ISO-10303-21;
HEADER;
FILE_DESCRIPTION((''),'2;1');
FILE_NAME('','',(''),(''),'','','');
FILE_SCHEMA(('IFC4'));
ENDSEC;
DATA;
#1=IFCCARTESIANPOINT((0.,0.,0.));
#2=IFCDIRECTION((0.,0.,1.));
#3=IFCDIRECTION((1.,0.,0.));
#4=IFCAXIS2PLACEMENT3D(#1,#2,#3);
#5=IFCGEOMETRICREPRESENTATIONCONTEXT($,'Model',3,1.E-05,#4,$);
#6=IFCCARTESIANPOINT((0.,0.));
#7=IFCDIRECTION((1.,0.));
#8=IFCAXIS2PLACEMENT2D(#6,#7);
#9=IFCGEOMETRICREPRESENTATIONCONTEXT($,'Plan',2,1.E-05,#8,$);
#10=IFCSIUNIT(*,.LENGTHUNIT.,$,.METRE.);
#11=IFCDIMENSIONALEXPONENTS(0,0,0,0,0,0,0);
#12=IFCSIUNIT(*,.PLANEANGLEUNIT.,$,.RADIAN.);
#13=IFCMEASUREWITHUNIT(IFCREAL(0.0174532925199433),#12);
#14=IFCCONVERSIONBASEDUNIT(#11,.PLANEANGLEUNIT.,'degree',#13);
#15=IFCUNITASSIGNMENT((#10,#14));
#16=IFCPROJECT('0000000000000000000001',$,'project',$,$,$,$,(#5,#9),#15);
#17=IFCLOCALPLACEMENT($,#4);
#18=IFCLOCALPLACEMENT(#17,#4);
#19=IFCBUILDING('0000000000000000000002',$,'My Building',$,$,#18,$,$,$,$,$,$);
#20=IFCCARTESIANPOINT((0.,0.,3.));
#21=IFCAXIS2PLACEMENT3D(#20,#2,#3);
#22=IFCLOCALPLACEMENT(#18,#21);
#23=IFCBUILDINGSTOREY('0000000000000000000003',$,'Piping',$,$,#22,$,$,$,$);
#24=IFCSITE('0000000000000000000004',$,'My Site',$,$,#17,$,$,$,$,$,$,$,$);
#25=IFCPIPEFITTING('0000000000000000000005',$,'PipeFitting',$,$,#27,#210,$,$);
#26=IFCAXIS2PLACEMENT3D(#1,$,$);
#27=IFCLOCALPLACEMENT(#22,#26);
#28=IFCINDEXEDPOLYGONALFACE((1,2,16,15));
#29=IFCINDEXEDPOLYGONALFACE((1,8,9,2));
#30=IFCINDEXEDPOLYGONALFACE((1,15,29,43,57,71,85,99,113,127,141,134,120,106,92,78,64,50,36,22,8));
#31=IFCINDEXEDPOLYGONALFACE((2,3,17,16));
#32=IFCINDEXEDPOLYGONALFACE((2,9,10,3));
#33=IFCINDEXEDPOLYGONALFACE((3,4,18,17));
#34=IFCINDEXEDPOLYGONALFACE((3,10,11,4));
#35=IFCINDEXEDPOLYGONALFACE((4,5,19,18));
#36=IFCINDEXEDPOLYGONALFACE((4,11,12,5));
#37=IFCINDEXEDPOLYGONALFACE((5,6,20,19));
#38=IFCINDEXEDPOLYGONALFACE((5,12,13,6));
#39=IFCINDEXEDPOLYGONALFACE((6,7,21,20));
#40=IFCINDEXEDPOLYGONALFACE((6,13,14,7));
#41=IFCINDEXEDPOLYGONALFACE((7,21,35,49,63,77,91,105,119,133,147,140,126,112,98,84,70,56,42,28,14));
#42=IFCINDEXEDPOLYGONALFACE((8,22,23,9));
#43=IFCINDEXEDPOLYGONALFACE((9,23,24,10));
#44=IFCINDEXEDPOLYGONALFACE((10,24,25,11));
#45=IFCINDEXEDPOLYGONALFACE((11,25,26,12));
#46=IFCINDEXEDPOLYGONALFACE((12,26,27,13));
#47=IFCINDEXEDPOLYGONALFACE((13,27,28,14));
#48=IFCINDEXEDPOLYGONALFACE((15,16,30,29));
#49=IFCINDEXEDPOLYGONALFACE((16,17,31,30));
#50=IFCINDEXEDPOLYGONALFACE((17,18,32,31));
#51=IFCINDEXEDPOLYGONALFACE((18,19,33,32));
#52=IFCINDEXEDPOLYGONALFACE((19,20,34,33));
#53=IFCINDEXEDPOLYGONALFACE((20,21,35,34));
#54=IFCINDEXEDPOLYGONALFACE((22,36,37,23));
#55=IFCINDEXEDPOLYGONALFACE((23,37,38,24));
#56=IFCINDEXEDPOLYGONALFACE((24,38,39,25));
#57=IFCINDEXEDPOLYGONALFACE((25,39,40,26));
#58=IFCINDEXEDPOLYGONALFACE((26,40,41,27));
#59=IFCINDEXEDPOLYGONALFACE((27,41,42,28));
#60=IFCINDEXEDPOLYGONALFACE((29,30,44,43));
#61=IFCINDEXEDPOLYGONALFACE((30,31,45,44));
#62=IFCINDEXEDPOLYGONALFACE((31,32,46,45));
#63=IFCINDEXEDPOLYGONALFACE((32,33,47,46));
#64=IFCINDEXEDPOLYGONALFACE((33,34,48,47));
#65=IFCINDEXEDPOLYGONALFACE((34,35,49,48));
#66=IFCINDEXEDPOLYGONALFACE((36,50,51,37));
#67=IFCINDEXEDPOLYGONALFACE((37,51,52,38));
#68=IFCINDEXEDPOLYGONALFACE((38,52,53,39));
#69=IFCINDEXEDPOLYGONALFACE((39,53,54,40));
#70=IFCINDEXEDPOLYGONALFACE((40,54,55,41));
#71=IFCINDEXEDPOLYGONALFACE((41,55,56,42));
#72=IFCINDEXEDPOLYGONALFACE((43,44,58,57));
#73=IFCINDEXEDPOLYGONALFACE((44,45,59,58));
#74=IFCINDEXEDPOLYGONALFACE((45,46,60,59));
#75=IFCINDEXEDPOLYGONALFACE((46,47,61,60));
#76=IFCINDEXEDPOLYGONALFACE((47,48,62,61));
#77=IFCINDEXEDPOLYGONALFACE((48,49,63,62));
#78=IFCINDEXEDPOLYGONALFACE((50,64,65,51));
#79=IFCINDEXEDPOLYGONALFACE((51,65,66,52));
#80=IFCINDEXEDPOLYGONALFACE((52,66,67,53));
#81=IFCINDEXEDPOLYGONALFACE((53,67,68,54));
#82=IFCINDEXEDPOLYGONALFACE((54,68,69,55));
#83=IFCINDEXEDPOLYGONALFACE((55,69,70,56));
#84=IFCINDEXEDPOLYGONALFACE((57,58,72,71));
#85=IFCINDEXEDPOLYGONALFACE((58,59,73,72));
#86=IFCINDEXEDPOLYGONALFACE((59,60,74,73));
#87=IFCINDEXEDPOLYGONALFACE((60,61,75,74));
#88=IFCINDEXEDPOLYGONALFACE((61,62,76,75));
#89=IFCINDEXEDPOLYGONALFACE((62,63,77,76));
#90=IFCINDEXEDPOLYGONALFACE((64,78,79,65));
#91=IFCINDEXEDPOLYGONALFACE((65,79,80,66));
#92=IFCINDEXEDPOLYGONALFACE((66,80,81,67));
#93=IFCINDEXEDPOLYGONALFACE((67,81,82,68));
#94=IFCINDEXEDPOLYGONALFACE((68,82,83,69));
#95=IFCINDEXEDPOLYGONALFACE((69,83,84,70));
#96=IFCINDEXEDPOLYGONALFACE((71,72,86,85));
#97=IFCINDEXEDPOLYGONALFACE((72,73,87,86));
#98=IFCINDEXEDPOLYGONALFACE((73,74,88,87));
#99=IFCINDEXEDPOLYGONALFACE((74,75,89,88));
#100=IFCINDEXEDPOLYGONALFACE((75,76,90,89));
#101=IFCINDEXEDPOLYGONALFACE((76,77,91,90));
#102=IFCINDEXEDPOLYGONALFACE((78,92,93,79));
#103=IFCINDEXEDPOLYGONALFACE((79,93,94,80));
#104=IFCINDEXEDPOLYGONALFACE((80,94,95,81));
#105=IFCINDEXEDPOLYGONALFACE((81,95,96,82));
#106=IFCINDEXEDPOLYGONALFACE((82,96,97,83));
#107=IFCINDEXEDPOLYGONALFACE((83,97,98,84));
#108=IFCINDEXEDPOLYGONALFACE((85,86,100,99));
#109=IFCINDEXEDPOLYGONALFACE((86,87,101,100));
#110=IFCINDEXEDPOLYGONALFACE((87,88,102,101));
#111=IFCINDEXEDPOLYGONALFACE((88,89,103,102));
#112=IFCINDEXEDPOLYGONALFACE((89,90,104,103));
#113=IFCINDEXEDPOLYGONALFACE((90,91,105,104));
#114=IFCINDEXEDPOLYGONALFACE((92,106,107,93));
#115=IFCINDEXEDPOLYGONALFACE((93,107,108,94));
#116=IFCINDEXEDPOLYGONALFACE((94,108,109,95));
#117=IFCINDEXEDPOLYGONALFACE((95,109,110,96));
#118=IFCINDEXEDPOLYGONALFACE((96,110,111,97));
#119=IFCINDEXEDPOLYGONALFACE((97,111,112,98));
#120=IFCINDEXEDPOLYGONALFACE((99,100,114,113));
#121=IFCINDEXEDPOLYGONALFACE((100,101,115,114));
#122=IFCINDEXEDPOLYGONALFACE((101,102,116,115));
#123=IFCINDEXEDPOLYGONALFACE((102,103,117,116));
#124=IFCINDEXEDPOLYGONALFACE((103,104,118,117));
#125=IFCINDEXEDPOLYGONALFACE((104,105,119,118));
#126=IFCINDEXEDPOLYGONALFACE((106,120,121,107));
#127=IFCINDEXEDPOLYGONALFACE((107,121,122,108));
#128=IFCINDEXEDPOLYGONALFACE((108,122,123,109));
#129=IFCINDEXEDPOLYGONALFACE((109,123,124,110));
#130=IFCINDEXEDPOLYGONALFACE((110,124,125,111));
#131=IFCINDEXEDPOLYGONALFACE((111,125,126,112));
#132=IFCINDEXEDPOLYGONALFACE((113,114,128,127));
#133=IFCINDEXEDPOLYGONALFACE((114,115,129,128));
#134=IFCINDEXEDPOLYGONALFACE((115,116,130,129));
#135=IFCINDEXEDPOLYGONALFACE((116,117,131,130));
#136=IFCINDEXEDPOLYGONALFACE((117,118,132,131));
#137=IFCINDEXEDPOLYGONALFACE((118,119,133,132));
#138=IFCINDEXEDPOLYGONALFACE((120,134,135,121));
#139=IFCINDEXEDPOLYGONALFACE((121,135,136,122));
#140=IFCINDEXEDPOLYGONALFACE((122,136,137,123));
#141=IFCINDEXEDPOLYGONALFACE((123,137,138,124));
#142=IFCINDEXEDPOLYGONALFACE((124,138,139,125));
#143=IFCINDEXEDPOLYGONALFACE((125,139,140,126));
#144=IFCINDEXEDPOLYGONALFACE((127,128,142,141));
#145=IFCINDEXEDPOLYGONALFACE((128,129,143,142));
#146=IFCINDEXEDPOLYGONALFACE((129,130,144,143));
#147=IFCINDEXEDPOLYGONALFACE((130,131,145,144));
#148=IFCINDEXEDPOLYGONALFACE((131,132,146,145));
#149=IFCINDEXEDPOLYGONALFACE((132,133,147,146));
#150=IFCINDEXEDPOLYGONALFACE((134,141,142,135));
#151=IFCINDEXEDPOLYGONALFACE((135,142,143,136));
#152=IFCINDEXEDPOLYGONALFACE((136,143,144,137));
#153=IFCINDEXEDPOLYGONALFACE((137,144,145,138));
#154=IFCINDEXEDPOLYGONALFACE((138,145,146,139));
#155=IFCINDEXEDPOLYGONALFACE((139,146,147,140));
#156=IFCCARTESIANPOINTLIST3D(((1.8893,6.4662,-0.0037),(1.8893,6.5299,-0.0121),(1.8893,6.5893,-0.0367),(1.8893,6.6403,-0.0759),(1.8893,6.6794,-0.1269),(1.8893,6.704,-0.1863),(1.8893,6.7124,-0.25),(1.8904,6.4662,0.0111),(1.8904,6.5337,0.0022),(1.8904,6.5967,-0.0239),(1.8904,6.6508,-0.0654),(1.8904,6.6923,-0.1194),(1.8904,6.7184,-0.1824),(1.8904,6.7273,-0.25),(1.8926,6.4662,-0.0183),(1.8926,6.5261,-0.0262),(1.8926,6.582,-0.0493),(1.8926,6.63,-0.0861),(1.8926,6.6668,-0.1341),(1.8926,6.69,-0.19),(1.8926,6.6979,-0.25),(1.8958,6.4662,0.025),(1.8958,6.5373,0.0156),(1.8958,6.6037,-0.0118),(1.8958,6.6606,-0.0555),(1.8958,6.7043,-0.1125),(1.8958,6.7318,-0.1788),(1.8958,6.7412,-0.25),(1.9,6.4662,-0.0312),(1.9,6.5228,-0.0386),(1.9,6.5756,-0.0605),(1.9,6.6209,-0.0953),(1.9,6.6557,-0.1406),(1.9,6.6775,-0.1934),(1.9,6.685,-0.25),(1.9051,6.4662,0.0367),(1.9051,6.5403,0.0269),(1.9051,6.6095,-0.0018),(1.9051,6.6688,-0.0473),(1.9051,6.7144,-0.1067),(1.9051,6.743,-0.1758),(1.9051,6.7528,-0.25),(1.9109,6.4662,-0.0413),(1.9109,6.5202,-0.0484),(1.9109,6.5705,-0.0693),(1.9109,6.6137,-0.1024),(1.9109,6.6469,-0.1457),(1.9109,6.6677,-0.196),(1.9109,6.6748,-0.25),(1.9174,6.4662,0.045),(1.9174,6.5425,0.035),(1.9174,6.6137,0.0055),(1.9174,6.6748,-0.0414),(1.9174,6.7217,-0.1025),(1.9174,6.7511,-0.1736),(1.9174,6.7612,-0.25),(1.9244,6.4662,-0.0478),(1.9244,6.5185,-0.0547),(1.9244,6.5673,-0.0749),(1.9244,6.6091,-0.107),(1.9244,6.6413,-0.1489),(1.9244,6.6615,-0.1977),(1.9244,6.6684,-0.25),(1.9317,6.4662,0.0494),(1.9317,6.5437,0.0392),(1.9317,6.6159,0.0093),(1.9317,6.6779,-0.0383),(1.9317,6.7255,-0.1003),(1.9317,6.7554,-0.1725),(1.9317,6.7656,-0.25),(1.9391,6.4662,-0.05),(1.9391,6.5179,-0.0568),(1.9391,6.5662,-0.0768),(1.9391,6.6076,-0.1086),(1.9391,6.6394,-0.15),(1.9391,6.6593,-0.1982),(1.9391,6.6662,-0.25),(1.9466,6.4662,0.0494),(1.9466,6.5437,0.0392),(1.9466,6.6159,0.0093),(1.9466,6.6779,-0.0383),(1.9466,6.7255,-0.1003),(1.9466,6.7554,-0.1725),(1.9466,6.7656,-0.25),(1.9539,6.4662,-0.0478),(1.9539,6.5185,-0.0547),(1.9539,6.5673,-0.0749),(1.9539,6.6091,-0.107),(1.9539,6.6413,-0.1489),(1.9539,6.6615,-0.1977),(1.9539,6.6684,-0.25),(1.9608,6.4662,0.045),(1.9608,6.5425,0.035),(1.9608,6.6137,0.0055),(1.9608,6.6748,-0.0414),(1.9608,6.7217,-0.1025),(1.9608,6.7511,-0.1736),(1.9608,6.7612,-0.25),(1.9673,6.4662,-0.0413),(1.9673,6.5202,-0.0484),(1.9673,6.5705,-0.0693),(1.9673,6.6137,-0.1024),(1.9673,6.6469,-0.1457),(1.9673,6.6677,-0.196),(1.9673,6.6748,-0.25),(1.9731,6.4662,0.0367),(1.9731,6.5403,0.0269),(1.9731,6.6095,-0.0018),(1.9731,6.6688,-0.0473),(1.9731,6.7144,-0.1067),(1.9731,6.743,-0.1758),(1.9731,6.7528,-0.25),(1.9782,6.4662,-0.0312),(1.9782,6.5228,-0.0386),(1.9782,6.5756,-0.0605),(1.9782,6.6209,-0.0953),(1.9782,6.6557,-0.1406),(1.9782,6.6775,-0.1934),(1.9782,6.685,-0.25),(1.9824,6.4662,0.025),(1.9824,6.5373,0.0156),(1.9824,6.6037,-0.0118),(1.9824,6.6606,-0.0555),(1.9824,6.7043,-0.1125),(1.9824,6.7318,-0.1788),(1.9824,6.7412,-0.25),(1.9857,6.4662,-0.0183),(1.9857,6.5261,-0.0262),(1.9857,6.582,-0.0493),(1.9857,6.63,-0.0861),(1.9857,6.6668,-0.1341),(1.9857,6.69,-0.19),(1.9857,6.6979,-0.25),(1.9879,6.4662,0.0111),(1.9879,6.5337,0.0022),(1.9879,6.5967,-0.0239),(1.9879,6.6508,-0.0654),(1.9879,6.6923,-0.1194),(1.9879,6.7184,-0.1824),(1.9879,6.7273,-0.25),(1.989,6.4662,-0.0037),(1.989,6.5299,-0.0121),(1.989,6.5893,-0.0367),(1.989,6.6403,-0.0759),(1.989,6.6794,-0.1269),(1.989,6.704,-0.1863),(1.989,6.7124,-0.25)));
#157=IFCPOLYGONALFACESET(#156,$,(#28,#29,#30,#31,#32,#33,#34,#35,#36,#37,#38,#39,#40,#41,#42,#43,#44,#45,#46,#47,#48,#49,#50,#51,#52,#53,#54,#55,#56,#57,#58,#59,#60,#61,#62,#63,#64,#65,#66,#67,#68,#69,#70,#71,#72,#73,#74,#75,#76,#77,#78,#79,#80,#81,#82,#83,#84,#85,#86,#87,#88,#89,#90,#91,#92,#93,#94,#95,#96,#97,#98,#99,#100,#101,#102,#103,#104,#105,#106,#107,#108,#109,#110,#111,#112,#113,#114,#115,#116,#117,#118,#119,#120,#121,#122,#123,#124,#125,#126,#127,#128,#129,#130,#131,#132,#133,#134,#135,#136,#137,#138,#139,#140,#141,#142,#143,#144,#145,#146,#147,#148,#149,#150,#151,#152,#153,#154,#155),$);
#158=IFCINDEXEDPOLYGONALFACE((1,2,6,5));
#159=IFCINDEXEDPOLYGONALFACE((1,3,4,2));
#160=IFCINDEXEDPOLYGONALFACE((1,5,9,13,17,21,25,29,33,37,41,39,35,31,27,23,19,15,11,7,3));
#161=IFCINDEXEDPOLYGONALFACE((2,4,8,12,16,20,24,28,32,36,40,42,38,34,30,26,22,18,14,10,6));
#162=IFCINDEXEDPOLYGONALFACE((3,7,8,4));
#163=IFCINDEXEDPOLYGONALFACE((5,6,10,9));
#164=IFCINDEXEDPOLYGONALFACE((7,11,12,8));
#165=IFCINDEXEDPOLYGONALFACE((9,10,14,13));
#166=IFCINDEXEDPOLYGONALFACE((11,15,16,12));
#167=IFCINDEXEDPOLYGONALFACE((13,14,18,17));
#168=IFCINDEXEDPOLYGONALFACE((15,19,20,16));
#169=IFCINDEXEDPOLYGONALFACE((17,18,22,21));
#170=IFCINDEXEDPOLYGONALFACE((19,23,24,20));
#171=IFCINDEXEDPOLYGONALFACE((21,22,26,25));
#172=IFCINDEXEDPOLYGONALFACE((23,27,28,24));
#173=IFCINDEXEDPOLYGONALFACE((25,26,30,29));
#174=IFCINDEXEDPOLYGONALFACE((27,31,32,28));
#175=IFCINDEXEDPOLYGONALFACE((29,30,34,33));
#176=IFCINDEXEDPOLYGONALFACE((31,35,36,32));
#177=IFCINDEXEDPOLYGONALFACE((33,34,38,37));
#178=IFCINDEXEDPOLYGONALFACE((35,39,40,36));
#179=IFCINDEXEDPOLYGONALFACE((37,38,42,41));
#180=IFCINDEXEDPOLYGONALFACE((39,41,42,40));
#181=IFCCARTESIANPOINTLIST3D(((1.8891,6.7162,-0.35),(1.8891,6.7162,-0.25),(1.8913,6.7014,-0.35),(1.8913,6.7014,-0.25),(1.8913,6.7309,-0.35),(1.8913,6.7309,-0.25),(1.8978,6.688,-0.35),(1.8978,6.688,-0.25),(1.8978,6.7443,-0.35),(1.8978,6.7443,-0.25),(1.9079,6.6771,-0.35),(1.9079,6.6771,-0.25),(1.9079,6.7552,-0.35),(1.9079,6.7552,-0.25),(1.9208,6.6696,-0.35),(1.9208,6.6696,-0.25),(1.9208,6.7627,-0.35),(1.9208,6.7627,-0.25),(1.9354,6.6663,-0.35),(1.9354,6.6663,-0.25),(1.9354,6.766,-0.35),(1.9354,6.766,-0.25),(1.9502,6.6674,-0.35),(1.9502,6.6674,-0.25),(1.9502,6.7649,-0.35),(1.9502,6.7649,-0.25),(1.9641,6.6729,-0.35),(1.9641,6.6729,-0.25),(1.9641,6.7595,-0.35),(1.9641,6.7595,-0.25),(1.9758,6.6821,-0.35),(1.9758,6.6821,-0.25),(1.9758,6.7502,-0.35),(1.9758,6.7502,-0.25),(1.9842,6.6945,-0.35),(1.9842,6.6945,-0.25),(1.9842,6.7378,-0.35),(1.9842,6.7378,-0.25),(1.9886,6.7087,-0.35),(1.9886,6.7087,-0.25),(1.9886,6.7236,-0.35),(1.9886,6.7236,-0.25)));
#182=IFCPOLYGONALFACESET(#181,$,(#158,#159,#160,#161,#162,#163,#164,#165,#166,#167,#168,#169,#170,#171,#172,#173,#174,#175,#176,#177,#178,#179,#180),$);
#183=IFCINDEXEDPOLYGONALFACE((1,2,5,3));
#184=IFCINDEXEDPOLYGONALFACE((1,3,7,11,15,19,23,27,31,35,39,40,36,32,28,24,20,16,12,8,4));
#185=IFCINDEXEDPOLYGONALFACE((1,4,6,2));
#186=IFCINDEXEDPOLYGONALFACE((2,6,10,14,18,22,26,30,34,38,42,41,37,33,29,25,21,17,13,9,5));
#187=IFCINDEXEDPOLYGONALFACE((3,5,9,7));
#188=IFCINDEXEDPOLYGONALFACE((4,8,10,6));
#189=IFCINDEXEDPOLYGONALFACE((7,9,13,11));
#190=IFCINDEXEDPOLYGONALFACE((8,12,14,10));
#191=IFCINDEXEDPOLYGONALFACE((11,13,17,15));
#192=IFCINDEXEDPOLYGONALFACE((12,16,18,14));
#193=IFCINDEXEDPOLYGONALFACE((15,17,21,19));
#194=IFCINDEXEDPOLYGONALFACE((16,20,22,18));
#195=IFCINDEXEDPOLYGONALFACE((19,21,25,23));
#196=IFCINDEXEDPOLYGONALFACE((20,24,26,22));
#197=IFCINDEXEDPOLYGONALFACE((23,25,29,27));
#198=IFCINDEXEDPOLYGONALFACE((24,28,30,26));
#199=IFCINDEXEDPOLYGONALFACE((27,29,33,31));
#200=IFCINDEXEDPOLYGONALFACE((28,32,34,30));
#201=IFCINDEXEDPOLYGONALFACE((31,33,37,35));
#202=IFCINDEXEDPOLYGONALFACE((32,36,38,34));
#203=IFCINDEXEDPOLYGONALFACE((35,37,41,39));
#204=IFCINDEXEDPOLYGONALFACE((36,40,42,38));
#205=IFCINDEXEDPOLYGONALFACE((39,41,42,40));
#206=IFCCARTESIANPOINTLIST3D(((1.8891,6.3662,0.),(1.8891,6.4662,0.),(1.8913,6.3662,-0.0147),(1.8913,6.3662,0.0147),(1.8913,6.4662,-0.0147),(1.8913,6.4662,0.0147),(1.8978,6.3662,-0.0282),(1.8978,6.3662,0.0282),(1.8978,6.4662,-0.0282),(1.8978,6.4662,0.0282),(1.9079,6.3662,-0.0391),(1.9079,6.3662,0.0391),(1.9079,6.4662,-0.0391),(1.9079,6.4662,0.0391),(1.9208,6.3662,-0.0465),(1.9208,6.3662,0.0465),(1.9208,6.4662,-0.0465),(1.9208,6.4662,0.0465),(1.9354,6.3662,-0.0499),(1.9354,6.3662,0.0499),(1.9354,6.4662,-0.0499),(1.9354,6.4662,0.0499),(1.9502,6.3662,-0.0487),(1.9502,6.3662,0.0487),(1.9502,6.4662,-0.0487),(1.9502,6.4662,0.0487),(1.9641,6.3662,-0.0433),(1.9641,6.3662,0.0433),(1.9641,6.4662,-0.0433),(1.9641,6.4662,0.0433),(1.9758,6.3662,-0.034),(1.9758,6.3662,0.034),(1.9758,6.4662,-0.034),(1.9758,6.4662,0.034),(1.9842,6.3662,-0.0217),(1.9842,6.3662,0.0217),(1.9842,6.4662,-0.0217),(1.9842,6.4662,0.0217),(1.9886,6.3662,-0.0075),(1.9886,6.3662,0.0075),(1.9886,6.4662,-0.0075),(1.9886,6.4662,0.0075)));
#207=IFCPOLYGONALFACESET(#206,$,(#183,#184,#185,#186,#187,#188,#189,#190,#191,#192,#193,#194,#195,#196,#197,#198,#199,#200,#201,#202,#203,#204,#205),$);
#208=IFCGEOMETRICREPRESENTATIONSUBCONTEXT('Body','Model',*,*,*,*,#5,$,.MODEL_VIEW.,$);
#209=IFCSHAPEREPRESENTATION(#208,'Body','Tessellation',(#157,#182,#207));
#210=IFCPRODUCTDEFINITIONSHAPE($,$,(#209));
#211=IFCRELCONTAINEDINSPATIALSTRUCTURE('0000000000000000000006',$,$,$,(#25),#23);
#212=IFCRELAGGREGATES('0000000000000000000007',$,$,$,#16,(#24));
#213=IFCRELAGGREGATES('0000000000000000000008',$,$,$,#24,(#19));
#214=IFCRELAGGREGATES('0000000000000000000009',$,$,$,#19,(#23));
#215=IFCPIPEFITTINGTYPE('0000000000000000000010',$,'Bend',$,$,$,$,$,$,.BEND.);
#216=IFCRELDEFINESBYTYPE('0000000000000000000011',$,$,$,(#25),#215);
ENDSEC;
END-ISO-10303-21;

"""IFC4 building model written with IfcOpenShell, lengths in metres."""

from ifc_helpers import new_model, entity, si_unit, converted_unit, frame, origin_with_axes, origin_2d_with_axis, place, context, subcontext, project, spatial, circle, extrude, source, transform, mapped, type_object, type_shapes, element, save


model = new_model("IFC4")

# Units and contexts
model_context = context("Model", 3, precision=1e-05, world=origin_with_axes())
plan_context = context("Plan", 2, precision=1e-05, world=origin_2d_with_axis())
body_context = subcontext(model_context, "Body", "Model", "MODEL_VIEW")
ifc_project = project(units=[si_unit("LENGTHUNIT", "METRE"), converted_unit("PLANEANGLEUNIT", "degree", entity("IfcReal", 0.0174532925199433), si_unit("PLANEANGLEUNIT", "RADIAN"), dimensions=[0, 0, 0, 0, 0, 0, 0])], contexts=[model_context, plan_context])

# Site, building, storey
site_placement = place(None, origin_with_axes())
site = spatial("IfcSite", under=ifc_project, at=site_placement, Name="My Site")
building_placement = place(site_placement, origin_with_axes())
building = spatial("IfcBuilding", under=site, at=building_placement, Name="My Building")
storey_placement = place(building_placement, frame((0.0, 0.0, 3.0), z_axis=(0.0, 0.0, 1.0), x_axis=(1.0, 0.0, 0.0)))
storey = spatial("IfcBuildingStorey", under=building, at=storey_placement, Name="Piping")

# Pipe fitting
pipe_fitting_type = type_object("IfcPipeFittingType", Name="Bend", PredefinedType="BEND")
shared_shape = source(origin_with_axes(), body_context, "Body", "SolidModel", [
    entity("IfcSweptDiskSolid", entity("IfcIndexedPolyCurve", entity("IfcCartesianPointList3D", [[0.0, 0.0, -0.1], [0.0, -0.0732, -0.2768], [0.0, -0.25, -0.35]]), [entity("IfcArcIndex", [1, 2, 3])]), 0.05),
    extrude(circle(Radius=0.05), origin_with_axes(), (0.0, 0.0, -1.0), 0.1),
    extrude(circle(Radius=0.05), frame((0.0, -0.25, -0.35), z_axis=(0.0, -1.0, 0.0), x_axis=(1.0, 0.0, 0.0)), (0.0, 0.0, 1.0), 0.1),
])
type_shapes(pipe_fitting_type, [shared_shape])
for number, where, z_axis, x_axis, name in (
    (1, (1.9391, 6.7162, -0.35), (0.0, 0.0, -1.0), (-1.0, 0.0, 0.0), "PipeFitting"),
):
    element("IfcPipeFitting", number, at=place(storey_placement, frame(where, z_axis=z_axis, x_axis=x_axis)), inside=storey, type_object=pipe_fitting_type, Name=name, context=body_context, shape_type="MappedRepresentation", body=[
        mapped(shared_shape, transform((0.0, 0.0, 0.0), x_axis=(1.0, 0.0, 0.0), y_axis=(0.0, 1.0, 0.0), z_axis=(0.0, 0.0, 1.0), scale=1.0)),
    ])

save(model, "model.ifc")
